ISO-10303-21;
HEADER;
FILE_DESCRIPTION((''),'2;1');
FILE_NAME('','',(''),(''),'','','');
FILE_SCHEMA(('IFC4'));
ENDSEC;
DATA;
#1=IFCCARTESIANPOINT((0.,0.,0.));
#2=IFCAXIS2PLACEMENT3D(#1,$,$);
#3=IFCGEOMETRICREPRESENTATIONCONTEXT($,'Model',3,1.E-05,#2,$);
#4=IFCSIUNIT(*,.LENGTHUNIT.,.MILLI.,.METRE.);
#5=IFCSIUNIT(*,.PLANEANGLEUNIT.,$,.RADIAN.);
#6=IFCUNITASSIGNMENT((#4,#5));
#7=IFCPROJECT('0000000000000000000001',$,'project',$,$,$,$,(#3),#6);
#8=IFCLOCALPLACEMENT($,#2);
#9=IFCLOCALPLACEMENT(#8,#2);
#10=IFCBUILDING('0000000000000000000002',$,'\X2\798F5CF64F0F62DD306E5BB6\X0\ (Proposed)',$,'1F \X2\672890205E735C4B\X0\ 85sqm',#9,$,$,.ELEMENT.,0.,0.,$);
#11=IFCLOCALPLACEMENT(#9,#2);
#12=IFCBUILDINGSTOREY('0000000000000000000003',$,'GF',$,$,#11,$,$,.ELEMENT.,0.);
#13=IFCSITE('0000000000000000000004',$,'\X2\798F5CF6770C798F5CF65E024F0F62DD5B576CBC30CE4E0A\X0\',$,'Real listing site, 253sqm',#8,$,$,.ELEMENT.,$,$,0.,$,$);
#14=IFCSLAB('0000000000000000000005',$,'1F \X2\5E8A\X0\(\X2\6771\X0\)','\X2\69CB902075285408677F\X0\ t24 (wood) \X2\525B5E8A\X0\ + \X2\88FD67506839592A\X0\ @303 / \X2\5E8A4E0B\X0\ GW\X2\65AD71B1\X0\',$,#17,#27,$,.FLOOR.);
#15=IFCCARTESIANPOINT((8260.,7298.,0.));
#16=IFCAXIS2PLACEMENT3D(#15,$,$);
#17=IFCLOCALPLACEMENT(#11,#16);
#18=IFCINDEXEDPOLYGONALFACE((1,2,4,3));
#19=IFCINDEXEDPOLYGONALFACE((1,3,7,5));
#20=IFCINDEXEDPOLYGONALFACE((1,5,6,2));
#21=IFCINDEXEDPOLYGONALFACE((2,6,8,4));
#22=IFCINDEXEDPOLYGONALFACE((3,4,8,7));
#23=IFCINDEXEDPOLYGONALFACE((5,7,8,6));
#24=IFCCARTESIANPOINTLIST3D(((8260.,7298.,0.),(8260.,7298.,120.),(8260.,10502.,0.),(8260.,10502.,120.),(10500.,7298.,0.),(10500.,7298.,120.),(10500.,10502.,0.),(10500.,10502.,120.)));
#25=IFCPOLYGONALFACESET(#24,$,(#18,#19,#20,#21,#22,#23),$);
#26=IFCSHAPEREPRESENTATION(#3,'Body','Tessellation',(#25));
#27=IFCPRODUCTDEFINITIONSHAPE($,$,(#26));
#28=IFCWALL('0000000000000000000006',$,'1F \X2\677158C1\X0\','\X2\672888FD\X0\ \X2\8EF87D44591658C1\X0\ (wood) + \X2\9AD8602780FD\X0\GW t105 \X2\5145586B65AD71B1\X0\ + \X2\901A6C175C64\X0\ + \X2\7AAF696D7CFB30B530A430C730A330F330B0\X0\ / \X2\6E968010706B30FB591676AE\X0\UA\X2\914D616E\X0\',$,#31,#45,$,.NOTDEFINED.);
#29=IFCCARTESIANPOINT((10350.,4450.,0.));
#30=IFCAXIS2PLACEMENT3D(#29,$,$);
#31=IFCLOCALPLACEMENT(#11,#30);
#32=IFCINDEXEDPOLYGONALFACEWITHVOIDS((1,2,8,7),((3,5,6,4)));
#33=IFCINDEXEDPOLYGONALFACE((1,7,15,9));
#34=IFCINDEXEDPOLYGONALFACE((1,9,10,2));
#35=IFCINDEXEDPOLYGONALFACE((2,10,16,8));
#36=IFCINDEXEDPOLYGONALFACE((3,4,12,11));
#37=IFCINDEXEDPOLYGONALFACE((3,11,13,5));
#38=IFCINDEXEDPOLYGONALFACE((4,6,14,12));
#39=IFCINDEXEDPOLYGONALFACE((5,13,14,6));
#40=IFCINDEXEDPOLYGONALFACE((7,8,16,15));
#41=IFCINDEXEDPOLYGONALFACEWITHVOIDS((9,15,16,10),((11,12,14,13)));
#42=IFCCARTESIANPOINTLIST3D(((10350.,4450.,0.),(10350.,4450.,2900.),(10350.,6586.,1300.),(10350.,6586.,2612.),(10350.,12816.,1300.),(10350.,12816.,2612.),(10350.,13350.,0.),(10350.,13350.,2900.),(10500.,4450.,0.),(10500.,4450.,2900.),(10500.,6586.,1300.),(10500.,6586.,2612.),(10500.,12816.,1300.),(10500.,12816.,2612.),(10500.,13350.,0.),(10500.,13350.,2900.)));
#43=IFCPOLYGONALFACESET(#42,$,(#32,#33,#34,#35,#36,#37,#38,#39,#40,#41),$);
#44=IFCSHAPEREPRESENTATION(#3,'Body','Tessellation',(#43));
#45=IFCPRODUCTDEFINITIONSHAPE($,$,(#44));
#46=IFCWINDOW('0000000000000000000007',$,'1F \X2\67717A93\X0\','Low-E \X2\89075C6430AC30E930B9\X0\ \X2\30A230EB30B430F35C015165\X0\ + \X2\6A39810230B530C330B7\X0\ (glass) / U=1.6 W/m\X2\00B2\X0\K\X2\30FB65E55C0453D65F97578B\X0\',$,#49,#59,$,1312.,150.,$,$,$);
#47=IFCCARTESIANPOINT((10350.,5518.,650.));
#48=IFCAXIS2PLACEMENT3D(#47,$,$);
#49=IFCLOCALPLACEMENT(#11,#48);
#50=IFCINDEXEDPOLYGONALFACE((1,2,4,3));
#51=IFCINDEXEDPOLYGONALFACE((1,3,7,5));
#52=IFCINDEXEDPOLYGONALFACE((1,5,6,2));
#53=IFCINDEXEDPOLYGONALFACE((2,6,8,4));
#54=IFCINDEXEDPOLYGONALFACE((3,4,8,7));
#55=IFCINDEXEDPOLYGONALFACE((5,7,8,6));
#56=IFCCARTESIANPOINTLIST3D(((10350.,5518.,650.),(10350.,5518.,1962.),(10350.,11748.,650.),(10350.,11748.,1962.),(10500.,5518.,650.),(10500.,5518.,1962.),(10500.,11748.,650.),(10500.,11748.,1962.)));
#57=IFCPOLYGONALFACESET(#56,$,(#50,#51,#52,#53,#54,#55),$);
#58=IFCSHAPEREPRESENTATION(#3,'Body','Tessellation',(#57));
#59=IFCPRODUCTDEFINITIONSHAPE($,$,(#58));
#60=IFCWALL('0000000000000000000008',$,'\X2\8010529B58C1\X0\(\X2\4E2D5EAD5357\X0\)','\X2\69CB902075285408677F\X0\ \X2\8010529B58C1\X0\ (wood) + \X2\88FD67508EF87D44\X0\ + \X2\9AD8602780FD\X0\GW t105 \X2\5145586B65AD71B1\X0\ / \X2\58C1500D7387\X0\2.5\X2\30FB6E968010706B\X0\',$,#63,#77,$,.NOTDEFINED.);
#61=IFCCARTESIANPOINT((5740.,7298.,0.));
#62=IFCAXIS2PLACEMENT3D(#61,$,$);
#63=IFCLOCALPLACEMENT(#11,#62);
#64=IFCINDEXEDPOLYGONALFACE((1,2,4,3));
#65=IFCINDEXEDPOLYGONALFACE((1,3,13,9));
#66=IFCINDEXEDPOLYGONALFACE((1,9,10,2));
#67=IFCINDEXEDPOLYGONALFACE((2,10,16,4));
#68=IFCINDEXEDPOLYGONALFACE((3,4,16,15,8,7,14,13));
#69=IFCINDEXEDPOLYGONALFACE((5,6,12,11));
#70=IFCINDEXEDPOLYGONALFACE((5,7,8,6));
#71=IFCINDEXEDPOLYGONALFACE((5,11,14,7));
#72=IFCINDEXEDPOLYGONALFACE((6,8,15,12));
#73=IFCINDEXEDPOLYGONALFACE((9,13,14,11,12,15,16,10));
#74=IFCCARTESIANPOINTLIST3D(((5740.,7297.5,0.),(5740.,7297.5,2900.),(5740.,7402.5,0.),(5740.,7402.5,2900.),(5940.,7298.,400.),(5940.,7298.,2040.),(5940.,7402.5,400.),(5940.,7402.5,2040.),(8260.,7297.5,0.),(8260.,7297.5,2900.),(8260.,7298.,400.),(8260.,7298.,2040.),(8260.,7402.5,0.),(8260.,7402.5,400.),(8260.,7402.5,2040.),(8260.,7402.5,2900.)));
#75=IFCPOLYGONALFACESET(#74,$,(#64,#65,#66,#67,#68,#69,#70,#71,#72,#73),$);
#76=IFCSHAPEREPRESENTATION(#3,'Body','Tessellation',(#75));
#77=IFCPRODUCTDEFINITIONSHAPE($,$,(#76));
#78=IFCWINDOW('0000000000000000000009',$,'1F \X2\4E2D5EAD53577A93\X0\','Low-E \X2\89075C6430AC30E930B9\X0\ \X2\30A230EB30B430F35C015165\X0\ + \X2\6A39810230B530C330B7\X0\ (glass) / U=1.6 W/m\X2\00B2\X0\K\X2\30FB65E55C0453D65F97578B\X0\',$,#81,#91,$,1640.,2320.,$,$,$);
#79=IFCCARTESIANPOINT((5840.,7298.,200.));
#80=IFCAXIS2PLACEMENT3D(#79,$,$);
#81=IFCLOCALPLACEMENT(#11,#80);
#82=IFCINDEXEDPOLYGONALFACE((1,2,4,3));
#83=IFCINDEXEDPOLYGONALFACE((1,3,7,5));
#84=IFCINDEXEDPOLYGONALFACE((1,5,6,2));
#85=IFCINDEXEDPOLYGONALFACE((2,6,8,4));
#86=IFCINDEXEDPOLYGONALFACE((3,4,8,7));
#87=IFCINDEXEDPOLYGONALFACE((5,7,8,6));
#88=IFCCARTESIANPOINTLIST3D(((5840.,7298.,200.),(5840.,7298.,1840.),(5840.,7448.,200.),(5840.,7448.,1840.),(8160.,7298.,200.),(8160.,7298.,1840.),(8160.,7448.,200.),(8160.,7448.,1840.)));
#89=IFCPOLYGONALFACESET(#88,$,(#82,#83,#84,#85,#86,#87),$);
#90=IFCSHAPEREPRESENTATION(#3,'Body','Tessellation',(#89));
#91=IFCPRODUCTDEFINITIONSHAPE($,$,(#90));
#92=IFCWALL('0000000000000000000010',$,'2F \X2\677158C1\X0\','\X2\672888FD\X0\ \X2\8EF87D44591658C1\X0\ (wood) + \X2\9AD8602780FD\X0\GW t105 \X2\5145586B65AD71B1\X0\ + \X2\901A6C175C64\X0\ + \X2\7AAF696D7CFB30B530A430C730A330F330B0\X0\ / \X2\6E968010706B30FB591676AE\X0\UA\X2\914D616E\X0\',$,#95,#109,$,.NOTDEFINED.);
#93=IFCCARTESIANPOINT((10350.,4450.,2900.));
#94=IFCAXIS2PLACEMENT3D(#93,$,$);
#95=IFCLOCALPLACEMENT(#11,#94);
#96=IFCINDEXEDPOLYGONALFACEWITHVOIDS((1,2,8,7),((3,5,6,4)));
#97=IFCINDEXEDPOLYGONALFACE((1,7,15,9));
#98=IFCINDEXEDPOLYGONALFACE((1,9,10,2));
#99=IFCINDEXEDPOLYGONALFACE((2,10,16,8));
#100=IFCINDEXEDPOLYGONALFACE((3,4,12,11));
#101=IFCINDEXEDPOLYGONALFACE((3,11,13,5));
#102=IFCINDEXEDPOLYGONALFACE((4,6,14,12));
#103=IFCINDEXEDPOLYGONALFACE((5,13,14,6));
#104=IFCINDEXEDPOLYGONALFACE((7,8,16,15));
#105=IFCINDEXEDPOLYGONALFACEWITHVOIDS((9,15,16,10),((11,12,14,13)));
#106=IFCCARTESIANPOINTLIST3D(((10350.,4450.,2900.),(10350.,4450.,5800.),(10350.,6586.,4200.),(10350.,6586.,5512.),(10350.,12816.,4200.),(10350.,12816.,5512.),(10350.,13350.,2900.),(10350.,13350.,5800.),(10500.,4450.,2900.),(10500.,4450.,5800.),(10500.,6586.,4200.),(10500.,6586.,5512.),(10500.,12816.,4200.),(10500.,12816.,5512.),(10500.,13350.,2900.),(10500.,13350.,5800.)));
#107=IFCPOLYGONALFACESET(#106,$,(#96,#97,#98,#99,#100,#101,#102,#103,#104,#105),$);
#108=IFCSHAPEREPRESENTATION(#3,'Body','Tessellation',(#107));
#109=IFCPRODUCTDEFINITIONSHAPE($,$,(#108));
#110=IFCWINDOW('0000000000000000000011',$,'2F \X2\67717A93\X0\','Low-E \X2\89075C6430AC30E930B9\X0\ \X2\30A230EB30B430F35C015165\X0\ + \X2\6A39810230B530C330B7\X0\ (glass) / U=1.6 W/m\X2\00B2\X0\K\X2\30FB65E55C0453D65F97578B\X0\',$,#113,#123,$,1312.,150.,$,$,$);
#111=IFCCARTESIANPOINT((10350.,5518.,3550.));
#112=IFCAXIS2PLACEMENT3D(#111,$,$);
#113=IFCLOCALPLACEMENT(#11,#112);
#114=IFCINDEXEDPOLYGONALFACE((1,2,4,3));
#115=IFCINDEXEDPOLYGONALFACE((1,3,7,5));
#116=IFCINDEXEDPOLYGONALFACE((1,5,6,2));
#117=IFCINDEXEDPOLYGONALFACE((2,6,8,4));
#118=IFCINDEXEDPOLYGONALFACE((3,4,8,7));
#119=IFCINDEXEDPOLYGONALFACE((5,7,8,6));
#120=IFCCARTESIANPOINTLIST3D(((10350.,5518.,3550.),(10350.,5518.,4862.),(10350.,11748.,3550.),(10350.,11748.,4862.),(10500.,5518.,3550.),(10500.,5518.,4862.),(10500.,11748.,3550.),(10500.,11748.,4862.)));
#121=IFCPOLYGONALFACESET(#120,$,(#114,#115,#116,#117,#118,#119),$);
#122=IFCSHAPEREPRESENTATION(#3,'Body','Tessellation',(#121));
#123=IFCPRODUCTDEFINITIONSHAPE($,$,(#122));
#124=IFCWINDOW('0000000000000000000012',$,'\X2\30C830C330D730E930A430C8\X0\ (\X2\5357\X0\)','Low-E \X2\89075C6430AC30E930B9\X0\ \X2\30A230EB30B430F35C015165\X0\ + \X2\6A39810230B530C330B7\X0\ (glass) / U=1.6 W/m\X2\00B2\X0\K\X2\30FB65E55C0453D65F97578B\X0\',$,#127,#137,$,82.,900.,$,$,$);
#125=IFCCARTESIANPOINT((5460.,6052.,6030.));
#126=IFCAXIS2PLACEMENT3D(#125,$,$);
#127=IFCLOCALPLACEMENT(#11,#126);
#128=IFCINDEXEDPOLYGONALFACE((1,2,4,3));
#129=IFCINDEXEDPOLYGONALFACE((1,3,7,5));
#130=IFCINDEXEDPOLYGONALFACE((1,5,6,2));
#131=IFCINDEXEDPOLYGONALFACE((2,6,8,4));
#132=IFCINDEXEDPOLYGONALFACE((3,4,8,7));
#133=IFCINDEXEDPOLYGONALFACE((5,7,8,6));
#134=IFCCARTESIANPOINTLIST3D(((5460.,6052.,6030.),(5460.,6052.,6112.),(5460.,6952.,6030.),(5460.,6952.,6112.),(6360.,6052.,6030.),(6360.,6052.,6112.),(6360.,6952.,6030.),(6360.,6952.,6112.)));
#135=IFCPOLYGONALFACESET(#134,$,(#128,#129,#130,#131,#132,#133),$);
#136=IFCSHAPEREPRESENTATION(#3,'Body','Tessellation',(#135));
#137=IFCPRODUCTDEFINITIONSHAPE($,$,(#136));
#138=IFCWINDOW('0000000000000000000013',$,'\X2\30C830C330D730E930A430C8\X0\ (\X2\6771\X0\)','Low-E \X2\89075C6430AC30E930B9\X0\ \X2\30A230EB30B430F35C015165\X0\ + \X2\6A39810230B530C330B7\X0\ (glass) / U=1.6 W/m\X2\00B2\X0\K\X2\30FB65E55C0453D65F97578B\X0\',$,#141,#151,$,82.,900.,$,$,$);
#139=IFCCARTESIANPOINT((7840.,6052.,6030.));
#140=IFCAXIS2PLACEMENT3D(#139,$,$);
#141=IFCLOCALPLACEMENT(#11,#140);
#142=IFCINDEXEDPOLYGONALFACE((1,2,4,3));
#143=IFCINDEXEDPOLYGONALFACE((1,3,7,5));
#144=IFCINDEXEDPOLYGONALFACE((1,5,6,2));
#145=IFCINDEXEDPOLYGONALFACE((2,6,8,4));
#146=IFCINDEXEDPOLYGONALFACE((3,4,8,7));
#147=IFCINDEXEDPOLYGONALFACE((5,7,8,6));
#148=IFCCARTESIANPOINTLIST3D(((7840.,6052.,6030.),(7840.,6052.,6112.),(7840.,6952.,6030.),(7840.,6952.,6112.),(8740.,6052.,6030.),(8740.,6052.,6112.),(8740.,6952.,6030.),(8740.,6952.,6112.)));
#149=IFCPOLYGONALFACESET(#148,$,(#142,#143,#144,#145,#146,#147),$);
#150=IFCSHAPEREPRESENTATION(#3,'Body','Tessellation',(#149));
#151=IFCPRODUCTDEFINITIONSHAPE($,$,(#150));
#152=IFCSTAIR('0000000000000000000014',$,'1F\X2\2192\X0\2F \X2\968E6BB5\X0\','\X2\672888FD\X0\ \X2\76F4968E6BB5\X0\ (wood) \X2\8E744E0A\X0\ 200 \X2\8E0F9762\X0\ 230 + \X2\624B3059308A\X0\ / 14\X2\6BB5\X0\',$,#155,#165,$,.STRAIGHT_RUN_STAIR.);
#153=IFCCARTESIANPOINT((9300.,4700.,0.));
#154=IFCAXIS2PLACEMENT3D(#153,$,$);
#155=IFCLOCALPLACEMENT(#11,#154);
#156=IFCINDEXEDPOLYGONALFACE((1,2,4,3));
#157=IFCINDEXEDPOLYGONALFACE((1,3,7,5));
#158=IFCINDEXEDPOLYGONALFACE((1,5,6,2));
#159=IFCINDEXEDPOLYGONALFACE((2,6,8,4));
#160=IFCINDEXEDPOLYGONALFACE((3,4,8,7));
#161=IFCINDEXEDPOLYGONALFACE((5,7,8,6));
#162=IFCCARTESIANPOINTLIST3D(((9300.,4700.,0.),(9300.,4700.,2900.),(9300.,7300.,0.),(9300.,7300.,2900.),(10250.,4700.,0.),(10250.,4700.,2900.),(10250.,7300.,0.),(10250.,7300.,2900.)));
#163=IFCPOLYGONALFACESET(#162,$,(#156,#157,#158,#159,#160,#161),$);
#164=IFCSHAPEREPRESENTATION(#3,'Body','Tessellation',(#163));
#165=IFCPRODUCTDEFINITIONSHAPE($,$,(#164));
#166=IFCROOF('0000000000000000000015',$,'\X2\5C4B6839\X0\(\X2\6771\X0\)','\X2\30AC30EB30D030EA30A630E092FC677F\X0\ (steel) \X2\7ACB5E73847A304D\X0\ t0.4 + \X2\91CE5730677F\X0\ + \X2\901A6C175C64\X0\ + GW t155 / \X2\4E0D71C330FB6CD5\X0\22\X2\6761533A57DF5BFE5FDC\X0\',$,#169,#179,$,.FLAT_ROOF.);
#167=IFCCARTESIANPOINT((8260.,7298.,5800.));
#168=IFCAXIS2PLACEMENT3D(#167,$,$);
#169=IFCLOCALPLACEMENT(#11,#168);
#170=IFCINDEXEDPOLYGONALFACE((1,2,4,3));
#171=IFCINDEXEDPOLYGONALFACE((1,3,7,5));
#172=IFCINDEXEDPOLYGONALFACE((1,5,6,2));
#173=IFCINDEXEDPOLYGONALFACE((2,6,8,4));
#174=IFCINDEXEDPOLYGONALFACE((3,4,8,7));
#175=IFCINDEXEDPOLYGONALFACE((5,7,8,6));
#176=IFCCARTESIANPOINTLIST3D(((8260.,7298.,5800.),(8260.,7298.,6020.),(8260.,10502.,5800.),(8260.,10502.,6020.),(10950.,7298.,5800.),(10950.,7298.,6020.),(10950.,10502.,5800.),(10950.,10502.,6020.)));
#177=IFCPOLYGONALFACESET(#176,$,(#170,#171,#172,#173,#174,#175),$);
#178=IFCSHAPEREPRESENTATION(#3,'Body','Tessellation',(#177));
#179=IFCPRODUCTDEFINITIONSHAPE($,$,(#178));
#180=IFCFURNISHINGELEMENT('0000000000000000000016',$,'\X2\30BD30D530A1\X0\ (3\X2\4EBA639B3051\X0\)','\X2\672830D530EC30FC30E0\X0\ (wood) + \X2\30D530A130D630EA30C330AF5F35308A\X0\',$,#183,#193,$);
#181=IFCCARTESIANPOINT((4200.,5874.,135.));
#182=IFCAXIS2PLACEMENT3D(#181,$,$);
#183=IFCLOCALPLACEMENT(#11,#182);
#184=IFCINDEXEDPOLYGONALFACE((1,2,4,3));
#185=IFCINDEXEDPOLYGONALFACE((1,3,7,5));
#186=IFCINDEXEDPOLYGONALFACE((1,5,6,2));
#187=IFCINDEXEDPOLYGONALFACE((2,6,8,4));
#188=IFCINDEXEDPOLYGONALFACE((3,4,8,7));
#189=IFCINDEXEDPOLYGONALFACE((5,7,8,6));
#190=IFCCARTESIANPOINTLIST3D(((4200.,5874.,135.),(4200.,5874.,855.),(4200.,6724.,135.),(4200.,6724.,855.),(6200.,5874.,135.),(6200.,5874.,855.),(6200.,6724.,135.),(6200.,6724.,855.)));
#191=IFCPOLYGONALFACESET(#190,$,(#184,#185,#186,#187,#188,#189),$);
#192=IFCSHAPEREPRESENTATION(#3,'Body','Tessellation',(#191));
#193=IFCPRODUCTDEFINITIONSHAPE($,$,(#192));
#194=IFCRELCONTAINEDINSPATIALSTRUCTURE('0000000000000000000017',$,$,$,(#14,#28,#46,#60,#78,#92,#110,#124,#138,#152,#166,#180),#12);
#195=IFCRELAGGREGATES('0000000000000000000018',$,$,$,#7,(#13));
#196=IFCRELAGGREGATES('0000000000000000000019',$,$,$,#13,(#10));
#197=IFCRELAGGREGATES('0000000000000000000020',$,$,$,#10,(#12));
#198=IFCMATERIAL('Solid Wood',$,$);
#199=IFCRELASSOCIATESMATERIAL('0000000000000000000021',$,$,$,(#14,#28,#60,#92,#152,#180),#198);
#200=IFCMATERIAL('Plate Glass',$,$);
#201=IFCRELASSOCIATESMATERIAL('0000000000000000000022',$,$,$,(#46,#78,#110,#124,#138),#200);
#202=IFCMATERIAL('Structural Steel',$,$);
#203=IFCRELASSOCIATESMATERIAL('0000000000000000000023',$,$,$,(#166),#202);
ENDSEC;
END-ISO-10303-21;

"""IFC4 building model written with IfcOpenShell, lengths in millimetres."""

from ifc_helpers import new_model, si_unit, frame, frame_2d, origin, place, context, project, spatial, rectangle, extrude, material, element, fill, save


model = new_model("IFC4")

# Units and contexts
model_context = context("Model", 3, precision=1e-05, world=origin())
ifc_project = project(units=[si_unit("LENGTHUNIT", "METRE", prefix="MILLI"), si_unit("PLANEANGLEUNIT", "RADIAN")], contexts=[model_context])

# Site, building, storey
site_placement = place(None, origin())
site = spatial("IfcSite", under=ifc_project, at=site_placement, Name="福島県福島市伏拝字沼ノ上", ObjectType="Real listing site, 253sqm", CompositionType="ELEMENT", RefElevation=0.0)
building_placement = place(site_placement, origin())
building = spatial("IfcBuilding", under=site, at=building_placement, Name="福島伏拝の家 (Proposed)", ObjectType="1F 木造平屋 85sqm", CompositionType="ELEMENT", ElevationOfRefHeight=0.0, ElevationOfTerrain=0.0)
storey_placement = place(building_placement, origin())
storey = spatial("IfcBuildingStorey", under=building, at=storey_placement, Name="GF", CompositionType="ELEMENT", Elevation=0.0)

# Slab
ifc_material_1 = material(Name="Solid Wood")
slab_placement = place(storey_placement, frame((8260.0, 7298.0, 0.0)))
element("IfcSlab", 1, at=slab_placement, inside=storey, material=ifc_material_1, Name="1F 床(東)", Description="構造用合板 t24 (wood) 剛床 + 製材根太 @303 / 床下 GW断熱", PredefinedType="FLOOR", context=model_context, shape_type="SweptSolid", body=[
    extrude(rectangle(XDim=2240.0, YDim=3204.0, at=frame_2d((1120.0, 1602.0))), frame((8260.0, 7298.0, 0.0)), (0.0, 0.0, 1.0), 120.0),
])

# Walls, openings, windows
wall_1_placement = place(storey_placement, frame((10350.0, 4450.0, 0.0)))
wall_1 = element("IfcWall", 2, at=wall_1_placement, inside=storey, material=ifc_material_1, Name="1F 東壁", Description="木製 軸組外壁 (wood) + 高性能GW t105 充填断熱 + 通気層 + 窯業系サイディング / 準耐火・外皮UA配慮", PredefinedType="NOTDEFINED", context=model_context, shape_type="SweptSolid", body=[
    extrude(rectangle(XDim=150.0, YDim=8900.0, at=frame_2d((75.0, 4450.0))), frame((10350.0, 4450.0, 0.0)), (0.0, 0.0, 1.0), 2900.0),
])
opening_1_placement = place(storey_placement, frame((10350.0, 5518.0, 650.0)))
opening_1 = element("IfcOpeningElement", 3, at=opening_1_placement, cuts=wall_1, PredefinedType="NOTDEFINED", context=model_context, shape_type="SweptSolid", body=[
    extrude(rectangle(XDim=150.0, YDim=6230.0, at=frame_2d((75.0, 3115.0))), frame((10350.0, 5518.0, 650.0)), (0.0, 0.0, 1.0), 1312.0),
])
ifc_material_2 = material(Name="Plate Glass")
window_1_placement = place(storey_placement, frame((10350.0, 5518.0, 650.0)))
window_1 = element("IfcWindow", 4, at=window_1_placement, inside=storey, material=ifc_material_2, Name="1F 東窓", Description="Low-E 複層ガラス アルゴン封入 + 樹脂サッシ (glass) / U=1.6 W/m²K・日射取得型", OverallHeight=1312.0, OverallWidth=150.0, context=model_context, shape_type="SweptSolid", body=[
    extrude(rectangle(XDim=150.0, YDim=6230.0, at=frame_2d((75.0, 3115.0))), frame((10350.0, 5518.0, 650.0)), (0.0, 0.0, 1.0), 1312.0),
])
fill(opening_1, window_1)
wall_2_placement = place(storey_placement, frame((5740.0, 7298.0, 0.0)))
wall_2 = element("IfcWall", 5, at=wall_2_placement, inside=storey, material=ifc_material_1, Name="耐力壁(中庭南)", Description="構造用合板 耐力壁 (wood) + 製材軸組 + 高性能GW t105 充填断熱 / 壁倍率2.5・準耐火", PredefinedType="NOTDEFINED", context=model_context, shape_type="SweptSolid", body=[
    extrude(rectangle(XDim=2520.0, YDim=105.0, at=frame_2d((1260.0, 52.0))), frame((5740.0, 7298.0, 0.0)), (0.0, 0.0, 1.0), 2900.0),
])
opening_2_placement = place(storey_placement, frame((5840.0, 7298.0, 200.0)))
opening_2 = element("IfcOpeningElement", 6, at=opening_2_placement, cuts=wall_2, PredefinedType="NOTDEFINED", context=model_context, shape_type="SweptSolid", body=[
    extrude(rectangle(XDim=2320.0, YDim=150.0, at=frame_2d((1160.0, 75.0))), frame((5840.0, 7298.0, 200.0)), (0.0, 0.0, 1.0), 1640.0),
])
window_2_placement = place(storey_placement, frame((5840.0, 7298.0, 200.0)))
window_2 = element("IfcWindow", 7, at=window_2_placement, inside=storey, material=ifc_material_2, Name="1F 中庭南窓", Description="Low-E 複層ガラス アルゴン封入 + 樹脂サッシ (glass) / U=1.6 W/m²K・日射取得型", OverallHeight=1640.0, OverallWidth=2320.0, context=model_context, shape_type="SweptSolid", body=[
    extrude(rectangle(XDim=2320.0, YDim=150.0, at=frame_2d((1160.0, 75.0))), frame((5840.0, 7298.0, 200.0)), (0.0, 0.0, 1.0), 1640.0),
])
fill(opening_2, window_2)

# Wall, opening, window
wall_3_placement = place(storey_placement, frame((10350.0, 4450.0, 2900.0)))
wall_3 = element("IfcWall", 8, at=wall_3_placement, inside=storey, material=ifc_material_1, Name="2F 東壁", Description="木製 軸組外壁 (wood) + 高性能GW t105 充填断熱 + 通気層 + 窯業系サイディング / 準耐火・外皮UA配慮", PredefinedType="NOTDEFINED", context=model_context, shape_type="SweptSolid", body=[
    extrude(rectangle(XDim=150.0, YDim=8900.0, at=frame_2d((75.0, 4450.0))), frame((10350.0, 4450.0, 2900.0)), (0.0, 0.0, 1.0), 2900.0),
])
opening_3_placement = place(storey_placement, frame((10350.0, 5518.0, 3550.0)))
opening_3 = element("IfcOpeningElement", 9, at=opening_3_placement, cuts=wall_3, PredefinedType="NOTDEFINED", context=model_context, shape_type="SweptSolid", body=[
    extrude(rectangle(XDim=150.0, YDim=6230.0, at=frame_2d((75.0, 3115.0))), frame((10350.0, 5518.0, 3550.0)), (0.0, 0.0, 1.0), 1312.0),
])
window_3_placement = place(storey_placement, frame((10350.0, 5518.0, 3550.0)))
window_3 = element("IfcWindow", 10, at=window_3_placement, inside=storey, material=ifc_material_2, Name="2F 東窓", Description="Low-E 複層ガラス アルゴン封入 + 樹脂サッシ (glass) / U=1.6 W/m²K・日射取得型", OverallHeight=1312.0, OverallWidth=150.0, context=model_context, shape_type="SweptSolid", body=[
    extrude(rectangle(XDim=150.0, YDim=6230.0, at=frame_2d((75.0, 3115.0))), frame((10350.0, 5518.0, 3550.0)), (0.0, 0.0, 1.0), 1312.0),
])
fill(opening_3, window_3)

# Windows
window_4_placement = place(storey_placement, frame((5460.0, 6052.0, 6030.0)))
element("IfcWindow", 11, at=window_4_placement, inside=storey, material=ifc_material_2, Name="トップライト (南)", Description="Low-E 複層ガラス アルゴン封入 + 樹脂サッシ (glass) / U=1.6 W/m²K・日射取得型", OverallHeight=82.0, OverallWidth=900.0, context=model_context, shape_type="SweptSolid", body=[
    extrude(rectangle(XDim=900.0, YDim=900.0, at=frame_2d((450.0, 450.0))), frame((5460.0, 6052.0, 6030.0)), (0.0, 0.0, 1.0), 82.0),
])
window_5_placement = place(storey_placement, frame((7840.0, 6052.0, 6030.0)))
element("IfcWindow", 12, at=window_5_placement, inside=storey, material=ifc_material_2, Name="トップライト (東)", Description="Low-E 複層ガラス アルゴン封入 + 樹脂サッシ (glass) / U=1.6 W/m²K・日射取得型", OverallHeight=82.0, OverallWidth=900.0, context=model_context, shape_type="SweptSolid", body=[
    extrude(rectangle(XDim=900.0, YDim=900.0, at=frame_2d((450.0, 450.0))), frame((7840.0, 6052.0, 6030.0)), (0.0, 0.0, 1.0), 82.0),
])

# Stair
stair_placement = place(storey_placement, frame((9300.0, 4700.0, 0.0)))
element("IfcStair", 13, at=stair_placement, inside=storey, material=ifc_material_1, Name="1F→2F 階段", Description="木製 直階段 (wood) 蹴上 200 踏面 230 + 手すり / 14段", PredefinedType="STRAIGHT_RUN_STAIR", context=model_context, shape_type="SweptSolid", body=[
    extrude(rectangle(XDim=950.0, YDim=2600.0, at=frame_2d((475.0, 1300.0))), frame((9300.0, 4700.0, 0.0)), (0.0, 0.0, 1.0), 2900.0),
])

# Roof
ifc_material_3 = material(Name="Structural Steel")
roof_placement = place(storey_placement, frame((8260.0, 7298.0, 5800.0)))
element("IfcRoof", 14, at=roof_placement, inside=storey, material=ifc_material_3, Name="屋根(東)", Description="ガルバリウム鋼板 (steel) 立平葺き t0.4 + 野地板 + 通気層 + GW t155 / 不燃・法22条区域対応", PredefinedType="FLAT_ROOF", context=model_context, shape_type="SweptSolid", body=[
    extrude(rectangle(XDim=2690.0, YDim=3204.0, at=frame_2d((1345.0, 1602.0))), frame((8260.0, 7298.0, 5800.0)), (0.0, 0.0, 1.0), 220.0),
])

# Furnishing element
furnishing_1_placement = place(storey_placement, frame((4200.0, 5874.0, 135.0)))
element("IfcFurnishingElement", 15, at=furnishing_1_placement, inside=storey, material=ifc_material_1, Name="ソファ (3人掛け)", Description="木フレーム (wood) + ファブリック張り", context=model_context, shape_type="SweptSolid", body=[
    extrude(rectangle(XDim=2000.0, YDim=850.0, at=frame_2d((1000.0, 425.0))), frame((4200.0, 5874.0, 135.0)), (0.0, 0.0, 1.0), 720.0),
])

save(model, "model.ifc")
